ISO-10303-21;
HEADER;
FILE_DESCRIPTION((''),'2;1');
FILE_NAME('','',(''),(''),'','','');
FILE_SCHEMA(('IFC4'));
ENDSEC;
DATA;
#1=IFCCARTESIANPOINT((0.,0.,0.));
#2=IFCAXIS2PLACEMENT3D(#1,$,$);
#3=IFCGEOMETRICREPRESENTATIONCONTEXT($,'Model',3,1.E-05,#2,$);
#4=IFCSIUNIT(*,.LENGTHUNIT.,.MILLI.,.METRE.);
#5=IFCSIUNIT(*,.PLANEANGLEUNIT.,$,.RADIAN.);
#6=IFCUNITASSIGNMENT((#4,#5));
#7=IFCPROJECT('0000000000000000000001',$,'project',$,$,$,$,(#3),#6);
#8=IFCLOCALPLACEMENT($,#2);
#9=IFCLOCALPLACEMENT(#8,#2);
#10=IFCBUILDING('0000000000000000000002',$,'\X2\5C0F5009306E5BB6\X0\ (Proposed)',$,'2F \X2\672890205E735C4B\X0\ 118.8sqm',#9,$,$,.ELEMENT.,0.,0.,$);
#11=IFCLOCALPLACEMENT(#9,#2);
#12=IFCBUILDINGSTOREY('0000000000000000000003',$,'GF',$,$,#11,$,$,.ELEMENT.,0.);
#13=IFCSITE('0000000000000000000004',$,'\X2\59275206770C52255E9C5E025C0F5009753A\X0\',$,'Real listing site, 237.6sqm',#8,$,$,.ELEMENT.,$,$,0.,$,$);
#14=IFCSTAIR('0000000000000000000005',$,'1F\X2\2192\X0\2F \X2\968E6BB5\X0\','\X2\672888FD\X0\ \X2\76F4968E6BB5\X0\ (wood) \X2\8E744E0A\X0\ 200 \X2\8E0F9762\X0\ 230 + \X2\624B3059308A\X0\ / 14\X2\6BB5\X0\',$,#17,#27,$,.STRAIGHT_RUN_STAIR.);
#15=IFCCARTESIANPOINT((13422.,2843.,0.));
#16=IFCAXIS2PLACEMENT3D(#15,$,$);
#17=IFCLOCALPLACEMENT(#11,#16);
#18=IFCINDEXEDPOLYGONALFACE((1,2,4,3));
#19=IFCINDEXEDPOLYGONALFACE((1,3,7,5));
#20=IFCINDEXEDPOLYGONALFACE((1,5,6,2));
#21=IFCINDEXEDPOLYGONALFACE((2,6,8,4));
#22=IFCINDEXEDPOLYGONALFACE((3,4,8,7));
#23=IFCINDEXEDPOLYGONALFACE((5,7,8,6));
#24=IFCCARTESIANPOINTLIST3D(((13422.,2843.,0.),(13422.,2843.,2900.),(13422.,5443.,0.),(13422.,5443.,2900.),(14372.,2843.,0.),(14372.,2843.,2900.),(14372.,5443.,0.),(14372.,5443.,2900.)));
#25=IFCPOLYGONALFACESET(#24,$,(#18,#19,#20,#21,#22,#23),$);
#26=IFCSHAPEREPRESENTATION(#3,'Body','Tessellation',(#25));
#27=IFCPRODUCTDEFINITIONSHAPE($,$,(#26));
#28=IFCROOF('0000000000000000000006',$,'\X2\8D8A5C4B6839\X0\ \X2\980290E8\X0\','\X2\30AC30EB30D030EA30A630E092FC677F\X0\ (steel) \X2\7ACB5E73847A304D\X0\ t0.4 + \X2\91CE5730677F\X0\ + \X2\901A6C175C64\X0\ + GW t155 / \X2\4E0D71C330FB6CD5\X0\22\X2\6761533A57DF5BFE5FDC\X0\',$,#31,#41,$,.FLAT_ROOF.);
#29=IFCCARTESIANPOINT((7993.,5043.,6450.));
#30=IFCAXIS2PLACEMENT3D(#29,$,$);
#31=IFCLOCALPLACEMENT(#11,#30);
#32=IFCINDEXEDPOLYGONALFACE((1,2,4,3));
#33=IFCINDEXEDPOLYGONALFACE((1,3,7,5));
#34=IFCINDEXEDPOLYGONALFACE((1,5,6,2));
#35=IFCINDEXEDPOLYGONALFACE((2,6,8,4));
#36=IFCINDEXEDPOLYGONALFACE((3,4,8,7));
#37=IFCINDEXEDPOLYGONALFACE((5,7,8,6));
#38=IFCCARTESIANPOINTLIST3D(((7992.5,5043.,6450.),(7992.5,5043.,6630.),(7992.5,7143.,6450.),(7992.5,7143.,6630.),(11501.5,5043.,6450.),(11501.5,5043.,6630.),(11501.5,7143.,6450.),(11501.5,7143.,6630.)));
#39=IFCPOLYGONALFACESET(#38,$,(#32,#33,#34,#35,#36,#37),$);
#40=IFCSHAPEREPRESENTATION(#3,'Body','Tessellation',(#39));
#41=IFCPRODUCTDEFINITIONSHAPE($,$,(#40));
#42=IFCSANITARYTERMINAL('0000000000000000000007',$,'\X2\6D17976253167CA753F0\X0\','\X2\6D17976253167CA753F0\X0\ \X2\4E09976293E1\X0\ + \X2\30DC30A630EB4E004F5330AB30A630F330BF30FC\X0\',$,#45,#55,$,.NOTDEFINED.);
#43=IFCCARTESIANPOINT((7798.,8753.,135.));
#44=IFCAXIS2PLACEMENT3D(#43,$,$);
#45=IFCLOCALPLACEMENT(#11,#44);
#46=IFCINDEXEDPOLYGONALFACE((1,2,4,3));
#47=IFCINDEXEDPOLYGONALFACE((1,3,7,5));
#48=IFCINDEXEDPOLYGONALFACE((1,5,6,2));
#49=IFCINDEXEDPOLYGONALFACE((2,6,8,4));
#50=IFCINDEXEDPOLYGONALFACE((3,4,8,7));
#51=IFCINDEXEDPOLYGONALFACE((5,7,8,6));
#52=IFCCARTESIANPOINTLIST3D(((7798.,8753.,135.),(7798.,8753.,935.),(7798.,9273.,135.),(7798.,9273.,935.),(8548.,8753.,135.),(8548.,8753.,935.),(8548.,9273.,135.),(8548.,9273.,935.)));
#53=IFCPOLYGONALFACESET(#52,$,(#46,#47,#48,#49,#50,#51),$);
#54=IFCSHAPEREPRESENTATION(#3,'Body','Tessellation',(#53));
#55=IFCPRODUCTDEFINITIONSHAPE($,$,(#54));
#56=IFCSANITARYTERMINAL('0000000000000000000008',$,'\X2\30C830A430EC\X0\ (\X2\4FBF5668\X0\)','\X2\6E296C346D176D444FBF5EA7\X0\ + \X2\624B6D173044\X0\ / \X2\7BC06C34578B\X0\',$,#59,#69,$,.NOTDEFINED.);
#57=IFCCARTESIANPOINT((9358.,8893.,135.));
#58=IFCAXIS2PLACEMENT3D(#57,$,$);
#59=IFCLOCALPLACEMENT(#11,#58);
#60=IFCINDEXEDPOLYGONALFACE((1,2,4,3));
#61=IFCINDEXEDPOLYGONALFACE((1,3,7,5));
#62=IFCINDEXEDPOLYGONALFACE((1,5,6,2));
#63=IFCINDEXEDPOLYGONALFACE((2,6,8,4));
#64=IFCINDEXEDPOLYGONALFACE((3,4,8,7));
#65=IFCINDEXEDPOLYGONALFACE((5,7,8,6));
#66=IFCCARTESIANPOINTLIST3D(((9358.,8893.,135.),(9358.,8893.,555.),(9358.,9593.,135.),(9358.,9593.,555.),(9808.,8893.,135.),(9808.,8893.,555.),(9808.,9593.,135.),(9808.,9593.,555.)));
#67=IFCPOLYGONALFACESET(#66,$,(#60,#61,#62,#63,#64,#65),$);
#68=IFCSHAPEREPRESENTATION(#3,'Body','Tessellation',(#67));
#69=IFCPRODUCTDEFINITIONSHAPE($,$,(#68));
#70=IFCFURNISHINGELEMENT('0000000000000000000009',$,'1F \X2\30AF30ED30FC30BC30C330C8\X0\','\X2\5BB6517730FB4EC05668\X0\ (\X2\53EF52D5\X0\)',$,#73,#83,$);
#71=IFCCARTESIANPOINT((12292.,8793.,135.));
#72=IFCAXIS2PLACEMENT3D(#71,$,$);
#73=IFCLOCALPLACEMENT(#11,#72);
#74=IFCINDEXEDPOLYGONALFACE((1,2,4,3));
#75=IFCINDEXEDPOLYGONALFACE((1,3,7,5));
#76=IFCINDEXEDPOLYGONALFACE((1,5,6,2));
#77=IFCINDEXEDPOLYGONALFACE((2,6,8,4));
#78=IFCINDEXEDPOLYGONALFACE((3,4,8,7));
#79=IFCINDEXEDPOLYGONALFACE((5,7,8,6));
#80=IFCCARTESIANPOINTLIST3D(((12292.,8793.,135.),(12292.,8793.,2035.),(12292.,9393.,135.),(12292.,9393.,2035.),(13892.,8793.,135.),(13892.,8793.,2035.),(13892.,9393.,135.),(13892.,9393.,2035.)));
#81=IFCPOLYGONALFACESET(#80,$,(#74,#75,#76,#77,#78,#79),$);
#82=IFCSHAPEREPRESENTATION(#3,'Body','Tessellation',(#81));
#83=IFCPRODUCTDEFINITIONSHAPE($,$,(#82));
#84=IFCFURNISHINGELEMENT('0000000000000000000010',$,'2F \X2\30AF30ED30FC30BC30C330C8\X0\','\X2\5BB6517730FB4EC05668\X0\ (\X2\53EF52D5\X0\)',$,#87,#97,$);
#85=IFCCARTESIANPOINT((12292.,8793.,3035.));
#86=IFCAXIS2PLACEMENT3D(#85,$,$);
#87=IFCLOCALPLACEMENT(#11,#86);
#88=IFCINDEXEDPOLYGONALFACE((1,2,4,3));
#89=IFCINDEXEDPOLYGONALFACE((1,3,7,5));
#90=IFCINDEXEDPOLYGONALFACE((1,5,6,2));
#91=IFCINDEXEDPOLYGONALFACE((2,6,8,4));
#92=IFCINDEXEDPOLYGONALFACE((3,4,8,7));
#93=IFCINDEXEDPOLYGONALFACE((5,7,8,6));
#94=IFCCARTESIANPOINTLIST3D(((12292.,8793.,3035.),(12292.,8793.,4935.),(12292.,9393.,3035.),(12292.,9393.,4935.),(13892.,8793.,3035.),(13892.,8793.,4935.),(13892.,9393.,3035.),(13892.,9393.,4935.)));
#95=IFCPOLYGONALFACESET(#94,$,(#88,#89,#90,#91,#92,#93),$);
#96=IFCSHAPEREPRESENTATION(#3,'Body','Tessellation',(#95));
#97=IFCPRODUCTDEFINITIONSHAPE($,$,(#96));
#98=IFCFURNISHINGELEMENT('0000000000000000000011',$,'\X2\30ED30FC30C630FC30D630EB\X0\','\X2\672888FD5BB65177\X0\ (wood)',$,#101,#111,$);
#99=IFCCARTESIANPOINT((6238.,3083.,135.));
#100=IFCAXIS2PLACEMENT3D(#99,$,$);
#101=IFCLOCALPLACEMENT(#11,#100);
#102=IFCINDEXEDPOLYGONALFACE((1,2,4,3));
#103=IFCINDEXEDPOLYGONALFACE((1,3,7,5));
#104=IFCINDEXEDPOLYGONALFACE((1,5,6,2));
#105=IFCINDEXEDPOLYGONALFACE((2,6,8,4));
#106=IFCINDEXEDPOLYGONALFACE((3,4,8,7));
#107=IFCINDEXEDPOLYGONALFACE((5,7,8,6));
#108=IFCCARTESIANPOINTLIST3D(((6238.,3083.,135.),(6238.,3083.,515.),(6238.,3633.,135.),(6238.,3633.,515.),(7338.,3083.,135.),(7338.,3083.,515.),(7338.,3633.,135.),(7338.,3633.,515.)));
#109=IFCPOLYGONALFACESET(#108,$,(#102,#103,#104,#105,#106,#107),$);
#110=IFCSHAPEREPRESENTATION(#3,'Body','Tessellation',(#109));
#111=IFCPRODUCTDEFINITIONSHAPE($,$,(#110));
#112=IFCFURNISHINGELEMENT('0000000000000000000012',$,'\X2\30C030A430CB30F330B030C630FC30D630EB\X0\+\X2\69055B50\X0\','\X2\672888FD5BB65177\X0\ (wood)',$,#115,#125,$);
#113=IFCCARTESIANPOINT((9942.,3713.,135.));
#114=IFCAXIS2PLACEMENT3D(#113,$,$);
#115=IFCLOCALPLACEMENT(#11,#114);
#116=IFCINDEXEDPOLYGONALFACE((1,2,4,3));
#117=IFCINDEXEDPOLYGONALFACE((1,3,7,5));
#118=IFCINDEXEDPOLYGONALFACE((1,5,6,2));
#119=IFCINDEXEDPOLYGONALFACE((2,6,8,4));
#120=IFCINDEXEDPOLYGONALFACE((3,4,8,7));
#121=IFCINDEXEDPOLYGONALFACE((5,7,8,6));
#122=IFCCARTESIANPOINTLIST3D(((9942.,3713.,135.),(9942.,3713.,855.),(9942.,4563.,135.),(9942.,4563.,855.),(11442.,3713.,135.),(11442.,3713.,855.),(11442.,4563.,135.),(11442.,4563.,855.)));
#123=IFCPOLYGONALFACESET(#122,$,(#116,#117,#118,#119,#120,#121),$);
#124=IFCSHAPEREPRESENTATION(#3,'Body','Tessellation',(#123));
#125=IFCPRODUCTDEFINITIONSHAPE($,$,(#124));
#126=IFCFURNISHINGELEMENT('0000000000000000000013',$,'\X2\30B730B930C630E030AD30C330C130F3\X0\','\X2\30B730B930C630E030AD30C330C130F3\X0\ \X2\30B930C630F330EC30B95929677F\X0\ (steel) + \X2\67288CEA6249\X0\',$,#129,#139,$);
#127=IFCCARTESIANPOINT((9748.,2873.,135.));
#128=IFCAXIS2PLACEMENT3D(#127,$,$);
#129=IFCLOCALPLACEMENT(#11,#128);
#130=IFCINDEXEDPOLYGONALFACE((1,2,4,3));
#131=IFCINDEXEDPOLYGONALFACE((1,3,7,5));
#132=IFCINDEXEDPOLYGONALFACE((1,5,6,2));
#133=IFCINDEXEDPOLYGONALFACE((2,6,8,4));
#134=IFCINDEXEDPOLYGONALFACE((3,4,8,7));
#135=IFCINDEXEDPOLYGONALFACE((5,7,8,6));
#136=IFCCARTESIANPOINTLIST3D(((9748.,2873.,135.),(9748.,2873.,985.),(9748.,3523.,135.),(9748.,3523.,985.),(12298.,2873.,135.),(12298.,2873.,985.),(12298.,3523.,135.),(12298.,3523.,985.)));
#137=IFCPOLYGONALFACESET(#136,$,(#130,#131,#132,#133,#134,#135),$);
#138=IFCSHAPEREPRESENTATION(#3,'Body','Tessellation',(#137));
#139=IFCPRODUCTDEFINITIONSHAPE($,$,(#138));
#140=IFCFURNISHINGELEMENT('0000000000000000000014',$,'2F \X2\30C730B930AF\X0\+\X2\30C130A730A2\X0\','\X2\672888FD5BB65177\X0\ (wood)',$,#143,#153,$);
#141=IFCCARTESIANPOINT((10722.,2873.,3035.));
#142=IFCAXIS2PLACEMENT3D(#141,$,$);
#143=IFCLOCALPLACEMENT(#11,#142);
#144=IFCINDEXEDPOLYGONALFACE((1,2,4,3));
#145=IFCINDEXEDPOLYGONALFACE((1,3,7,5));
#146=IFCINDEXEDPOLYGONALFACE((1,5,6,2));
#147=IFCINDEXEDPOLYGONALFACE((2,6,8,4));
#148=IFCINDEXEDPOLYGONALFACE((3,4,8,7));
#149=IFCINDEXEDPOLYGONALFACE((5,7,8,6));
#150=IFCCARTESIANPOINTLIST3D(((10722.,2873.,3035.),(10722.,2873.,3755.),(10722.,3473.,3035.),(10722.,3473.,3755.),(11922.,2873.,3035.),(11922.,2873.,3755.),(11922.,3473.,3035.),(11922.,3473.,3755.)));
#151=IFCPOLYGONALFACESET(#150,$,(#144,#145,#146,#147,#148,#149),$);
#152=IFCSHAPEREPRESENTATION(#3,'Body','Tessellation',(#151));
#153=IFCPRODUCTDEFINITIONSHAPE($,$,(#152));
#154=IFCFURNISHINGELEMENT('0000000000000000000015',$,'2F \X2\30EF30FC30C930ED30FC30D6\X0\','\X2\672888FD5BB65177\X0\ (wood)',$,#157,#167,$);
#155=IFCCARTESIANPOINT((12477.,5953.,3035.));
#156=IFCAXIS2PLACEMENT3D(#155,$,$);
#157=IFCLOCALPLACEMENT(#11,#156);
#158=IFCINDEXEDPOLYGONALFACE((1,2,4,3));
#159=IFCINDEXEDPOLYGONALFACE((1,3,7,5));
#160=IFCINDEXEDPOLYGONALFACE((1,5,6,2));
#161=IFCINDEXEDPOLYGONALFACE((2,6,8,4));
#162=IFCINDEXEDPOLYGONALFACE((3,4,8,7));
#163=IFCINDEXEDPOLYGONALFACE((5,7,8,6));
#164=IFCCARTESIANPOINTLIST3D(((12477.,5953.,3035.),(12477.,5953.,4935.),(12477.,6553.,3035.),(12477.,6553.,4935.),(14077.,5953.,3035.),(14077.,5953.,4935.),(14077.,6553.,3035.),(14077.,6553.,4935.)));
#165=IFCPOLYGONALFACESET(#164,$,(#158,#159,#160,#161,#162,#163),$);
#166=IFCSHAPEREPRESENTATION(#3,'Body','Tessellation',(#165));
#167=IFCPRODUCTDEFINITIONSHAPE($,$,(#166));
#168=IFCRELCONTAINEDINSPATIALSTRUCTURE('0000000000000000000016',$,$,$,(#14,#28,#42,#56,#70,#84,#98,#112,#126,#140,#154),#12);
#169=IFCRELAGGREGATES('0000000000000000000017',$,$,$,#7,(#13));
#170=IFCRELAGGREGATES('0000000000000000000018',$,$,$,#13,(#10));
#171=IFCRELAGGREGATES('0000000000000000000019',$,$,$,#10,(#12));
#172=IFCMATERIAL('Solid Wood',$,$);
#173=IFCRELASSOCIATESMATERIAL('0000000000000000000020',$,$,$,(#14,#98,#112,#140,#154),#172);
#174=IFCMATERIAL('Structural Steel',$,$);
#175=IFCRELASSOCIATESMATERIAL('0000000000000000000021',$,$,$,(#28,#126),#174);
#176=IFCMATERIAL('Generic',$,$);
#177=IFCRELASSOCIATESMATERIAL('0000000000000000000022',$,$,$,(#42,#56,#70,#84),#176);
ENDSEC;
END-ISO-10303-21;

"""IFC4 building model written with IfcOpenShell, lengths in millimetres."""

from ifc_helpers import new_model, si_unit, frame, frame_2d, origin, place, context, project, spatial, rectangle, extrude, material, element, save


model = new_model("IFC4")

# Units and contexts
model_context = context("Model", 3, precision=1e-05, world=origin())
ifc_project = project(units=[si_unit("LENGTHUNIT", "METRE", prefix="MILLI"), si_unit("PLANEANGLEUNIT", "RADIAN")], contexts=[model_context])

# Site, building, storey
site_placement = place(None, origin())
site = spatial("IfcSite", under=ifc_project, at=site_placement, Name="大分県別府市小倉町", ObjectType="Real listing site, 237.6sqm", CompositionType="ELEMENT", RefElevation=0.0)
building_placement = place(site_placement, origin())
building = spatial("IfcBuilding", under=site, at=building_placement, Name="小倉の家 (Proposed)", ObjectType="2F 木造平屋 118.8sqm", CompositionType="ELEMENT", ElevationOfRefHeight=0.0, ElevationOfTerrain=0.0)
storey_placement = place(building_placement, origin())
storey = spatial("IfcBuildingStorey", under=building, at=storey_placement, Name="GF", CompositionType="ELEMENT", Elevation=0.0)

# Shared definitions
ifc_material_1 = material(Name="Solid Wood")

# Stair
stair_placement = place(storey_placement, frame((13422.0, 2843.0, 0.0)))
element("IfcStair", 1, at=stair_placement, inside=storey, material=ifc_material_1, Name="1F→2F 階段", Description="木製 直階段 (wood) 蹴上 200 踏面 230 + 手すり / 14段", PredefinedType="STRAIGHT_RUN_STAIR", context=model_context, shape_type="SweptSolid", body=[
    extrude(rectangle(XDim=950.0, YDim=2600.0, at=frame_2d((475.0, 1300.0))), frame((13422.0, 2843.0, 0.0)), (0.0, 0.0, 1.0), 2900.0),
])

# Roof
ifc_material_2 = material(Name="Structural Steel")
roof_placement = place(storey_placement, frame((7993.0, 5043.0, 6450.0)))
element("IfcRoof", 2, at=roof_placement, inside=storey, material=ifc_material_2, Name="越屋根 頂部", Description="ガルバリウム鋼板 (steel) 立平葺き t0.4 + 野地板 + 通気層 + GW t155 / 不燃・法22条区域対応", PredefinedType="FLAT_ROOF", context=model_context, shape_type="SweptSolid", body=[
    extrude(rectangle(XDim=3509.0, YDim=2100.0, at=frame_2d((1754.0, 1050.0))), frame((7993.0, 5043.0, 6450.0)), (0.0, 0.0, 1.0), 180.0),
])

# Sanitary terminals
ifc_material_3 = material(Name="Generic")
sanitary_terminal_1_placement = place(storey_placement, frame((7798.0, 8753.0, 135.0)))
element("IfcSanitaryTerminal", 3, at=sanitary_terminal_1_placement, inside=storey, material=ifc_material_3, Name="洗面化粧台", Description="洗面化粧台 三面鏡 + ボウル一体カウンター", PredefinedType="NOTDEFINED", context=model_context, shape_type="SweptSolid", body=[
    extrude(rectangle(XDim=750.0, YDim=520.0, at=frame_2d((375.0, 260.0))), frame((7798.0, 8753.0, 135.0)), (0.0, 0.0, 1.0), 800.0),
])
sanitary_terminal_2_placement = place(storey_placement, frame((9358.0, 8893.0, 135.0)))
element("IfcSanitaryTerminal", 4, at=sanitary_terminal_2_placement, inside=storey, material=ifc_material_3, Name="トイレ (便器)", Description="温水洗浄便座 + 手洗い / 節水型", PredefinedType="NOTDEFINED", context=model_context, shape_type="SweptSolid", body=[
    extrude(rectangle(XDim=450.0, YDim=700.0, at=frame_2d((225.0, 350.0))), frame((9358.0, 8893.0, 135.0)), (0.0, 0.0, 1.0), 420.0),
])

# Furnishing elements
furnishing_1_placement = place(storey_placement, frame((12292.0, 8793.0, 135.0)))
element("IfcFurnishingElement", 5, at=furnishing_1_placement, inside=storey, material=ifc_material_3, Name="1F クローゼット", Description="家具・什器 (可動)", context=model_context, shape_type="SweptSolid", body=[
    extrude(rectangle(XDim=1600.0, YDim=600.0, at=frame_2d((800.0, 300.0))), frame((12292.0, 8793.0, 135.0)), (0.0, 0.0, 1.0), 1900.0),
])
furnishing_2_placement = place(storey_placement, frame((12292.0, 8793.0, 3035.0)))
element("IfcFurnishingElement", 6, at=furnishing_2_placement, inside=storey, material=ifc_material_3, Name="2F クローゼット", Description="家具・什器 (可動)", context=model_context, shape_type="SweptSolid", body=[
    extrude(rectangle(XDim=1600.0, YDim=600.0, at=frame_2d((800.0, 300.0))), frame((12292.0, 8793.0, 3035.0)), (0.0, 0.0, 1.0), 1900.0),
])
furnishing_3_placement = place(storey_placement, frame((6238.0, 3083.0, 135.0)))
element("IfcFurnishingElement", 7, at=furnishing_3_placement, inside=storey, material=ifc_material_1, Name="ローテーブル", Description="木製家具 (wood)", context=model_context, shape_type="SweptSolid", body=[
    extrude(rectangle(XDim=1100.0, YDim=550.0, at=frame_2d((550.0, 275.0))), frame((6238.0, 3083.0, 135.0)), (0.0, 0.0, 1.0), 380.0),
])
furnishing_4_placement = place(storey_placement, frame((9942.0, 3713.0, 135.0)))
element("IfcFurnishingElement", 8, at=furnishing_4_placement, inside=storey, material=ifc_material_1, Name="ダイニングテーブル+椅子", Description="木製家具 (wood)", context=model_context, shape_type="SweptSolid", body=[
    extrude(rectangle(XDim=1500.0, YDim=850.0, at=frame_2d((750.0, 425.0))), frame((9942.0, 3713.0, 135.0)), (0.0, 0.0, 1.0), 720.0),
])
furnishing_5_placement = place(storey_placement, frame((9748.0, 2873.0, 135.0)))
element("IfcFurnishingElement", 9, at=furnishing_5_placement, inside=storey, material=ifc_material_2, Name="システムキッチン", Description="システムキッチン ステンレス天板 (steel) + 木質扉", context=model_context, shape_type="SweptSolid", body=[
    extrude(rectangle(XDim=2550.0, YDim=650.0, at=frame_2d((1275.0, 325.0))), frame((9748.0, 2873.0, 135.0)), (0.0, 0.0, 1.0), 850.0),
])
furnishing_6_placement = place(storey_placement, frame((10722.0, 2873.0, 3035.0)))
element("IfcFurnishingElement", 10, at=furnishing_6_placement, inside=storey, material=ifc_material_1, Name="2F デスク+チェア", Description="木製家具 (wood)", context=model_context, shape_type="SweptSolid", body=[
    extrude(rectangle(XDim=1200.0, YDim=600.0, at=frame_2d((600.0, 300.0))), frame((10722.0, 2873.0, 3035.0)), (0.0, 0.0, 1.0), 720.0),
])
furnishing_7_placement = place(storey_placement, frame((12477.0, 5953.0, 3035.0)))
element("IfcFurnishingElement", 11, at=furnishing_7_placement, inside=storey, material=ifc_material_1, Name="2F ワードローブ", Description="木製家具 (wood)", context=model_context, shape_type="SweptSolid", body=[
    extrude(rectangle(XDim=1600.0, YDim=600.0, at=frame_2d((800.0, 300.0))), frame((12477.0, 5953.0, 3035.0)), (0.0, 0.0, 1.0), 1900.0),
])

save(model, "model.ifc")
